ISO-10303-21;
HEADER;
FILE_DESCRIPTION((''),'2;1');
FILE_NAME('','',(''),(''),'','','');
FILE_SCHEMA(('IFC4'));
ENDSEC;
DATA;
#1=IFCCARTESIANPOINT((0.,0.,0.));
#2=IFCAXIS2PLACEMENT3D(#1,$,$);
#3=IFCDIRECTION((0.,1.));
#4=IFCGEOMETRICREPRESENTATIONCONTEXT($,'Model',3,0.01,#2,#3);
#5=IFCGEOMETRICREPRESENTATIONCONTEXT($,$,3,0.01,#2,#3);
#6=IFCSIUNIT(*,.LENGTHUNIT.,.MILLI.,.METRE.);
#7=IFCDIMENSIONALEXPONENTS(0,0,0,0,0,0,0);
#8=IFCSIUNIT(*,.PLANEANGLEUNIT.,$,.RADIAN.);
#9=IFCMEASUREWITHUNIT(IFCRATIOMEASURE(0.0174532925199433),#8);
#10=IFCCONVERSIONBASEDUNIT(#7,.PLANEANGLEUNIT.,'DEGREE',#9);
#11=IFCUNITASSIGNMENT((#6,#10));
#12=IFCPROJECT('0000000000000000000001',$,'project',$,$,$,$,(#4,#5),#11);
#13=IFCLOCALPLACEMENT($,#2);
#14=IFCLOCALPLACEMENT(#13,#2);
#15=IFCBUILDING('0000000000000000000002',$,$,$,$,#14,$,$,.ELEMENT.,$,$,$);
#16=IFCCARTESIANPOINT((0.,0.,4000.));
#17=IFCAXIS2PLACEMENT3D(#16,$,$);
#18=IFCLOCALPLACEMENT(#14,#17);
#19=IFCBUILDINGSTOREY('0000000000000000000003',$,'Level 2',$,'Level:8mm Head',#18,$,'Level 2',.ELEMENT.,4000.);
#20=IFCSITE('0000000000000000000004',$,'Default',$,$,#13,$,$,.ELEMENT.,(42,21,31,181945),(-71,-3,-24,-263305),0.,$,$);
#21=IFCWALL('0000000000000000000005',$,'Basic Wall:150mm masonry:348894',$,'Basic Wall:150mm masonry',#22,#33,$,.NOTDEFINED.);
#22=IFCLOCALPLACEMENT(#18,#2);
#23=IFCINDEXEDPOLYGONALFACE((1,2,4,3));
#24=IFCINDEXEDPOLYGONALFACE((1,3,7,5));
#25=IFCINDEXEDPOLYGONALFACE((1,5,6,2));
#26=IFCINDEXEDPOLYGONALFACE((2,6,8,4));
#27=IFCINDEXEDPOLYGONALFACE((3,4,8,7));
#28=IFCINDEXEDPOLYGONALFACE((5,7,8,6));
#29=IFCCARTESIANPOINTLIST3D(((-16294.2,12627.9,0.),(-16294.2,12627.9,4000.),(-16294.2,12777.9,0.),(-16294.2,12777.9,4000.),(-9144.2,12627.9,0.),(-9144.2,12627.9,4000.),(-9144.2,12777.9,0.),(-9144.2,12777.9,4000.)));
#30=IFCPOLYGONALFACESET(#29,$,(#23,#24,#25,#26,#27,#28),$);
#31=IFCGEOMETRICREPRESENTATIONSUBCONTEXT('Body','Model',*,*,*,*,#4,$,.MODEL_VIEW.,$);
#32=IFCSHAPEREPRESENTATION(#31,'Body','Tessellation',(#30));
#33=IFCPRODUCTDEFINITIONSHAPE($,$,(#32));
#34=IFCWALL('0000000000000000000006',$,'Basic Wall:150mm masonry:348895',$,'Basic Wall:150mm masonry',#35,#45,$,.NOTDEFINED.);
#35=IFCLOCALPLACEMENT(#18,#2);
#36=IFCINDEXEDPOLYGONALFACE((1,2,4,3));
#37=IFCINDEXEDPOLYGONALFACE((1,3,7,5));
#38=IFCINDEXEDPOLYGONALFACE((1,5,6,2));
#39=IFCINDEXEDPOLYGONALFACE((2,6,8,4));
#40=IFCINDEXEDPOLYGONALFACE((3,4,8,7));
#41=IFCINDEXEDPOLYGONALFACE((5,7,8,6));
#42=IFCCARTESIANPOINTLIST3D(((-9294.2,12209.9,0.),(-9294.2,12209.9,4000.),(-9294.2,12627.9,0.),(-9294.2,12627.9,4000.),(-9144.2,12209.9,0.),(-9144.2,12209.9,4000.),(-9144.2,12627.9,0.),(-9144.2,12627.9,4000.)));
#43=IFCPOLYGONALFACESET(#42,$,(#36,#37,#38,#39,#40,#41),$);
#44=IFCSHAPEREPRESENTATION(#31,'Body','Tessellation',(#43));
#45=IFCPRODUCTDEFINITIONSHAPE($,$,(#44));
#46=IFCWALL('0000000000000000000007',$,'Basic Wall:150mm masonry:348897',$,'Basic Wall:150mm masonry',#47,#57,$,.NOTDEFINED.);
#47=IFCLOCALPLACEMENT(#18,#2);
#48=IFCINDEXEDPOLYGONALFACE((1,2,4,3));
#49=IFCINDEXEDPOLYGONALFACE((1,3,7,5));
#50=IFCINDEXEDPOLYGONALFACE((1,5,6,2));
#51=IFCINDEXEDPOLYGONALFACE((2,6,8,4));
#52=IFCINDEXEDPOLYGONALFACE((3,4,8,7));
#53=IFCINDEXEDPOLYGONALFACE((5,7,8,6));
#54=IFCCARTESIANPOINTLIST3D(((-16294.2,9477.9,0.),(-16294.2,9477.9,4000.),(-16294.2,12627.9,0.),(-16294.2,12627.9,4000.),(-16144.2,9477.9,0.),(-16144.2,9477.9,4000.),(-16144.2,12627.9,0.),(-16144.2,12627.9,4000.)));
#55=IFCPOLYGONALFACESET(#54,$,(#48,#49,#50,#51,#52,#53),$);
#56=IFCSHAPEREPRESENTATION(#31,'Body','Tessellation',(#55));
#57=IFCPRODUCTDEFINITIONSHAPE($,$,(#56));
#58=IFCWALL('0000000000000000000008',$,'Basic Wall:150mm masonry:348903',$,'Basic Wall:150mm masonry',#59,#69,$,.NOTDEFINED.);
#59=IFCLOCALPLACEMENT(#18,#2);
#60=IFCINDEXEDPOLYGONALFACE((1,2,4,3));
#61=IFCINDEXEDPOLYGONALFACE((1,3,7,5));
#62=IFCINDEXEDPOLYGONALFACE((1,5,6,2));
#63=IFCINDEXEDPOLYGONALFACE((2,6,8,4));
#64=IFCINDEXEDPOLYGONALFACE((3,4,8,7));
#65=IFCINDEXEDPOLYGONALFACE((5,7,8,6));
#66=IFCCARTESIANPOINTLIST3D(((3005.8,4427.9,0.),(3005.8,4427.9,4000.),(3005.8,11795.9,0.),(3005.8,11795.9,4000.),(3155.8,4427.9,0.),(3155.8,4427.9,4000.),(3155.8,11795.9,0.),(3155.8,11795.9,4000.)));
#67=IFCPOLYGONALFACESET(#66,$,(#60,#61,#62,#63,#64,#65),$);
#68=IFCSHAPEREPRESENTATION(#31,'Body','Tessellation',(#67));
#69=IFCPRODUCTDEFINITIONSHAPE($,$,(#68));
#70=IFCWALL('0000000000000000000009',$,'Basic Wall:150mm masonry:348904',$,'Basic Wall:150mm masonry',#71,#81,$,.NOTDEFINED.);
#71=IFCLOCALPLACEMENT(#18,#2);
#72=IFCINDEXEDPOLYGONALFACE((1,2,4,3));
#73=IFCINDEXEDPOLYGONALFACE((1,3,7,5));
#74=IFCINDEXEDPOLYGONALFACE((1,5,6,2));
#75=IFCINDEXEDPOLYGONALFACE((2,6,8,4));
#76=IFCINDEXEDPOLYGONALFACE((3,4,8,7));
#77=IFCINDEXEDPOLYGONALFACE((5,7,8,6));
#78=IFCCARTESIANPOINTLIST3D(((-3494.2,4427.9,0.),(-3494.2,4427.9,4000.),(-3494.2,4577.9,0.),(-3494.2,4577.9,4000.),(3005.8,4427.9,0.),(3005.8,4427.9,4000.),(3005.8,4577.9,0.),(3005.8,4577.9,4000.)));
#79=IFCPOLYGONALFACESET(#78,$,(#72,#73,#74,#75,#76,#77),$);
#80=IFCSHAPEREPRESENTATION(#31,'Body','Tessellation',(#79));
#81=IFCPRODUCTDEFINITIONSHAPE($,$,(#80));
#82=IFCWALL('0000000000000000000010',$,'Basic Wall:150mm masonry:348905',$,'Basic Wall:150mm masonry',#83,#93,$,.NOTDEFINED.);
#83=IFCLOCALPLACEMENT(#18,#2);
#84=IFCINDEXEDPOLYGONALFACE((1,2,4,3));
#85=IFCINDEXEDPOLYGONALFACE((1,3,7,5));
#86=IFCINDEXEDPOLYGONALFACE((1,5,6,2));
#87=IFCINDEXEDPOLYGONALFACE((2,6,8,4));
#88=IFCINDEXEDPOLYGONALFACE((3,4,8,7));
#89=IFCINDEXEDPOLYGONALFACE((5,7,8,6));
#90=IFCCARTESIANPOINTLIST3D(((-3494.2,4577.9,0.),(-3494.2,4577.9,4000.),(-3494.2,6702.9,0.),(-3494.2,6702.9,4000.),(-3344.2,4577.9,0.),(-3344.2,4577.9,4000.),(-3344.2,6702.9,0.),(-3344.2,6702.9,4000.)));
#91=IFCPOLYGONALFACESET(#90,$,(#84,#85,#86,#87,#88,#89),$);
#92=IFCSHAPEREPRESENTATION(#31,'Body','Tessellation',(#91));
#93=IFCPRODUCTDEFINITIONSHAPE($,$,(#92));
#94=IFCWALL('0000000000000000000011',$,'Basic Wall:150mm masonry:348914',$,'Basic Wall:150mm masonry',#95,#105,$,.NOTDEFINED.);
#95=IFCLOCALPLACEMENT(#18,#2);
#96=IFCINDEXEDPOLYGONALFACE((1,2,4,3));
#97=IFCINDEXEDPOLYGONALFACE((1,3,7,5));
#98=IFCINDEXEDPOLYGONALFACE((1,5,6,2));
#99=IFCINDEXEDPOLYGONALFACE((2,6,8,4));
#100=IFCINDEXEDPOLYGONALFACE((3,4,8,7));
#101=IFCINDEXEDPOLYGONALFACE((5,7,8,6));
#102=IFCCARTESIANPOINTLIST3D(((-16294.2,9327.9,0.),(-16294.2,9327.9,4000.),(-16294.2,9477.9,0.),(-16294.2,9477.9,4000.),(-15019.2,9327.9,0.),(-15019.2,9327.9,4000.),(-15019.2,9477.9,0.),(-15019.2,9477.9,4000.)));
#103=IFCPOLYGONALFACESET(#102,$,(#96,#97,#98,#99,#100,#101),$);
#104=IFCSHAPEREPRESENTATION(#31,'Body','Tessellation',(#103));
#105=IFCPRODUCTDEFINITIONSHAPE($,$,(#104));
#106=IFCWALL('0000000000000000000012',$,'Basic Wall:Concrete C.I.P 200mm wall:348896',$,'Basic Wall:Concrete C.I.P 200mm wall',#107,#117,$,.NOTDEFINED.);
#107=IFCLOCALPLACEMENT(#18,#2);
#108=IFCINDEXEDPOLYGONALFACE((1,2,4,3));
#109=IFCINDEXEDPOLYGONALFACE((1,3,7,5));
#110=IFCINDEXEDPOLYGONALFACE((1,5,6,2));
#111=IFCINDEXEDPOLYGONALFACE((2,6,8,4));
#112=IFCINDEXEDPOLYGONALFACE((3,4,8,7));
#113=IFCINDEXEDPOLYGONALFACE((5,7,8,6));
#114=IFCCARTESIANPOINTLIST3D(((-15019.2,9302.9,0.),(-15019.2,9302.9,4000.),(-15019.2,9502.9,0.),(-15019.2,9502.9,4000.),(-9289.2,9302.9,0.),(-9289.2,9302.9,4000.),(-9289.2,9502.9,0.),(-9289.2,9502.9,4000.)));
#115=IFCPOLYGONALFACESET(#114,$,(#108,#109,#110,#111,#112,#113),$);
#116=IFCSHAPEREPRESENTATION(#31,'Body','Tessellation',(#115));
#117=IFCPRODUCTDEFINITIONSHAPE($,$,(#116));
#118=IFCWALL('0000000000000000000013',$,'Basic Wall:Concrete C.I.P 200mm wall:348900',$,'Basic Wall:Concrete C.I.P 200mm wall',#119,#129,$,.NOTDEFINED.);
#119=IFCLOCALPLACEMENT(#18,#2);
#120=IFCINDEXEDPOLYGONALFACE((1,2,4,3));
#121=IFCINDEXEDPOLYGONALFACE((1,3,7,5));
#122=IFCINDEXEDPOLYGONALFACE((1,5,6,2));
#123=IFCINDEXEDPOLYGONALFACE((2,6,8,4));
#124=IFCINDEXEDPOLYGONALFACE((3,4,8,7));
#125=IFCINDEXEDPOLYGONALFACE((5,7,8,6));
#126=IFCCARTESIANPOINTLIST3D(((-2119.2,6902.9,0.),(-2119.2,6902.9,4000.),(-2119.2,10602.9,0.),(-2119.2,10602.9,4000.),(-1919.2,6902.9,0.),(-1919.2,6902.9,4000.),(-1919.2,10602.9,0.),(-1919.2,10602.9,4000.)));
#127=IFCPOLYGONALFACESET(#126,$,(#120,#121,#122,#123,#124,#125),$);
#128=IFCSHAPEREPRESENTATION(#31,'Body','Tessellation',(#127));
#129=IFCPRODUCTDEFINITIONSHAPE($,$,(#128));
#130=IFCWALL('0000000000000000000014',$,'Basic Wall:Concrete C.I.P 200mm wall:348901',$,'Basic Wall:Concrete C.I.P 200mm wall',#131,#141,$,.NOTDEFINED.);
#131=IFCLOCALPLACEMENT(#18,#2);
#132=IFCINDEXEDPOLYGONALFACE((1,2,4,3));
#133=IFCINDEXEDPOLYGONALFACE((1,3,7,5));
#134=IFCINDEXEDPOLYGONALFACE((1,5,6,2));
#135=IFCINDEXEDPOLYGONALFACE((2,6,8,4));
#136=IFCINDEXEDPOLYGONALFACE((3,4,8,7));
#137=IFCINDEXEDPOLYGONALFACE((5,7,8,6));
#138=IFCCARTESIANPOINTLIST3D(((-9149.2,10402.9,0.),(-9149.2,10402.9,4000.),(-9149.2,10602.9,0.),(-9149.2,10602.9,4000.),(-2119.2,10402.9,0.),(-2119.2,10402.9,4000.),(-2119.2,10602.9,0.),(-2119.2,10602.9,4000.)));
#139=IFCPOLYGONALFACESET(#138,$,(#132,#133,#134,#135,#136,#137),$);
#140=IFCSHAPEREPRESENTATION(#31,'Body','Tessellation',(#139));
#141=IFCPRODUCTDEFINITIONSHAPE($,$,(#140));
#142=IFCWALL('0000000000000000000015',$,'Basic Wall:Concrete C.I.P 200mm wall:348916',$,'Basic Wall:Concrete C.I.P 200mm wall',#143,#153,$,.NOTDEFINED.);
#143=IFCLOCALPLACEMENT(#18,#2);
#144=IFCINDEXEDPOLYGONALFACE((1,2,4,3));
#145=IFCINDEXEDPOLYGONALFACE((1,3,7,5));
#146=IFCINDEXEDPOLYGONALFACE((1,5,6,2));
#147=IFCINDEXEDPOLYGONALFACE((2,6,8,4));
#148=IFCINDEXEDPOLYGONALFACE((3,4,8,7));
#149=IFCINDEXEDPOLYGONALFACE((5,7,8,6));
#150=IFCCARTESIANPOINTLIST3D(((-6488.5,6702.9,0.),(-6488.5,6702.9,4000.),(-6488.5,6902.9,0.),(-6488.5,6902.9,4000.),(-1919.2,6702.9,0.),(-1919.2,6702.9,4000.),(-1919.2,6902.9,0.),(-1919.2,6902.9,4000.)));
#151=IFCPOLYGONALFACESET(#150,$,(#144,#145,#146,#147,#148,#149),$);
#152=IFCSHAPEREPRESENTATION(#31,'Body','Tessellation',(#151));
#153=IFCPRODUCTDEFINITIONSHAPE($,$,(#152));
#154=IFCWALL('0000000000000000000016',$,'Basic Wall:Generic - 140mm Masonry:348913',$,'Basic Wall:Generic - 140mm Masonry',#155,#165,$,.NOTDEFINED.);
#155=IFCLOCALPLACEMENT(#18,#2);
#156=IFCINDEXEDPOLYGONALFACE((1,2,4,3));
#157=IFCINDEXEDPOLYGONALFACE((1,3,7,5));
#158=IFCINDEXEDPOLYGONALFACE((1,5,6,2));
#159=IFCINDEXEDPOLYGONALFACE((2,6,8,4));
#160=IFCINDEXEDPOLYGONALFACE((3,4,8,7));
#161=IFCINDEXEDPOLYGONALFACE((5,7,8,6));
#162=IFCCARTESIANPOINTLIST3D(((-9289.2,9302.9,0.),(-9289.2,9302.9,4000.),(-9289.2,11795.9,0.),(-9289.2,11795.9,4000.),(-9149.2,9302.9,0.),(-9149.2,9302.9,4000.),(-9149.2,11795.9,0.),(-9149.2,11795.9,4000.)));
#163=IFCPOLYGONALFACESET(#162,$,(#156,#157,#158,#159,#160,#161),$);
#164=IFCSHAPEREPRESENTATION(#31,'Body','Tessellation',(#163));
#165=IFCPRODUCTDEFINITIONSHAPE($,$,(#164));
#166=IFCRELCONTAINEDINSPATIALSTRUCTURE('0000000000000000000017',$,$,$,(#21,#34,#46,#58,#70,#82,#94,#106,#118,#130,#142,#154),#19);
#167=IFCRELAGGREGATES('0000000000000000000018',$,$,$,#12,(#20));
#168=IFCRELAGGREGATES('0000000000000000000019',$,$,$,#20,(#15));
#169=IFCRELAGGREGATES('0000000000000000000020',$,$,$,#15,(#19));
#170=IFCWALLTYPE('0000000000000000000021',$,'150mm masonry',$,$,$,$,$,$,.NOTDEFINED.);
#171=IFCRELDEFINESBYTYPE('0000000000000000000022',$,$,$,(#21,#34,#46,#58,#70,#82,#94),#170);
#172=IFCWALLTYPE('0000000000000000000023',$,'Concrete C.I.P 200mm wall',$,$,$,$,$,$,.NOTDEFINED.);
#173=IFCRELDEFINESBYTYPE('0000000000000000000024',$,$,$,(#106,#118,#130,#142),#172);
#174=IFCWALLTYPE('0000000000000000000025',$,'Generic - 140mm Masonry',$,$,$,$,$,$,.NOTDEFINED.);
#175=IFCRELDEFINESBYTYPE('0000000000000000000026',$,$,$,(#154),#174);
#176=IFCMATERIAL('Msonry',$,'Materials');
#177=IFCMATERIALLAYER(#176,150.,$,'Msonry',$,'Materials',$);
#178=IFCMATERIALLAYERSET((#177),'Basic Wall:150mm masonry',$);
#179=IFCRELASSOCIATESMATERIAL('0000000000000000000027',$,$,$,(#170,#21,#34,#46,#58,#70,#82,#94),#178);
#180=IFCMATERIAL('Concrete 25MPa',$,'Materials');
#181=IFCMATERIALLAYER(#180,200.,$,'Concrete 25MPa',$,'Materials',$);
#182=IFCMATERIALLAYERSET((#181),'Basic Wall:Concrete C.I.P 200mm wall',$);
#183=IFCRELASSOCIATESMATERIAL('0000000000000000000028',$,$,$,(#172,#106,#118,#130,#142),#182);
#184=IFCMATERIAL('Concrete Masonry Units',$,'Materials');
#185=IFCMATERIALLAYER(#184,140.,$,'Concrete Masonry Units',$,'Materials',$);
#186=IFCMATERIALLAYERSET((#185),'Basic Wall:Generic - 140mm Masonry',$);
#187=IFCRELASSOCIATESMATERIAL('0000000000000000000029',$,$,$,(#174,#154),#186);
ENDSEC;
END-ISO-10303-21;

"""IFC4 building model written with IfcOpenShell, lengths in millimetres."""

from ifc_helpers import new_model, entity, si_unit, converted_unit, direction, frame, frame_2d, origin, place, context, subcontext, project, spatial, rectangle, extrude, material, layer, layer_set, layer_usage, type_object, element, save


model = new_model("IFC4")

# Units and contexts
model_context = context("Model", 3, precision=0.01, world=origin(), true_north=direction((0.0, 1.0)))
context_of_model = context(None, 3, precision=0.01, world=origin(), true_north=direction((0.0, 1.0)))
body_context = subcontext(model_context, "Body", "Model", "MODEL_VIEW")
ifc_project = project(units=[si_unit("LENGTHUNIT", "METRE", prefix="MILLI"), converted_unit("PLANEANGLEUNIT", "DEGREE", entity("IfcRatioMeasure", 0.0174532925199433), si_unit("PLANEANGLEUNIT", "RADIAN"), dimensions=[0, 0, 0, 0, 0, 0, 0])], contexts=[model_context, context_of_model])

# Site, building, storey
site_placement = place(None, origin())
site = spatial("IfcSite", under=ifc_project, at=site_placement, Name="Default", CompositionType="ELEMENT", RefLatitude=(42, 21, 31, 181945), RefLongitude=(-71, -3, -24, -263305), RefElevation=0.0)
building_placement = place(site_placement, origin())
building = spatial("IfcBuilding", under=site, at=building_placement, CompositionType="ELEMENT")
storey_placement = place(building_placement, frame((0.0, 0.0, 4000.0)))
storey = spatial("IfcBuildingStorey", under=building, at=storey_placement, Name="Level 2", ObjectType="Level:8mm Head", LongName="Level 2", CompositionType="ELEMENT", Elevation=4000.0)

# Walls
ifc_material_1 = material(Name="Msonry", Category="Materials")
ifc_layer_1 = layer(ifc_material_1, 150.0, Name="Msonry", Category="Materials")
ifc_layer_set_1 = layer_set([ifc_layer_1], Name="Basic Wall:150mm masonry")
ifc_layer_usage_1 = layer_usage(ifc_layer_set_1, "AXIS2", "NEGATIVE", 75.0)
wall_type_1 = type_object("IfcWallType", Name="150mm masonry", PredefinedType="NOTDEFINED", material=ifc_layer_set_1)
wall_1_placement = place(storey_placement, frame((-16294.2, 12702.9, 0.0)))
element("IfcWall", 1, at=wall_1_placement, inside=storey, type_object=wall_type_1, material=ifc_layer_usage_1, Name="Basic Wall:150mm masonry:348894", ObjectType="Basic Wall:150mm masonry", PredefinedType="NOTDEFINED", context=body_context, shape_type="SweptSolid", body=[
    extrude(rectangle(XDim=7150.0, YDim=150.0, at=frame_2d((3575.0, 0.0), x_axis=(-1.0, 0.0))), origin(), (0.0, 0.0, 1.0), 4000.0),
])
ifc_layer_usage_2 = layer_usage(ifc_layer_set_1, "AXIS2", "NEGATIVE", 75.0)
wall_2_placement = place(storey_placement, frame((-9219.2, 12627.9, 0.0), z_axis=(0.0, 0.0, 1.0), x_axis=(0.0, -1.0, 0.0)))
element("IfcWall", 2, at=wall_2_placement, inside=storey, type_object=wall_type_1, material=ifc_layer_usage_2, Name="Basic Wall:150mm masonry:348895", ObjectType="Basic Wall:150mm masonry", PredefinedType="NOTDEFINED", context=body_context, shape_type="SweptSolid", body=[
    extrude(rectangle(XDim=418.0, YDim=150.0, at=frame_2d((209.0, 0.0), x_axis=(-1.0, 0.0))), origin(), (0.0, 0.0, 1.0), 4000.0),
])
ifc_layer_usage_3 = layer_usage(ifc_layer_set_1, "AXIS2", "NEGATIVE", 75.0)
wall_3_placement = place(storey_placement, frame((-16219.2, 9477.9, 0.0), z_axis=(0.0, 0.0, 1.0), x_axis=(0.0, 1.0, 0.0)))
element("IfcWall", 3, at=wall_3_placement, inside=storey, type_object=wall_type_1, material=ifc_layer_usage_3, Name="Basic Wall:150mm masonry:348897", ObjectType="Basic Wall:150mm masonry", PredefinedType="NOTDEFINED", context=body_context, shape_type="SweptSolid", body=[
    extrude(rectangle(XDim=3150.0, YDim=150.0, at=frame_2d((1575.0, 0.0), x_axis=(-1.0, 0.0))), origin(), (0.0, 0.0, 1.0), 4000.0),
])
ifc_layer_usage_4 = layer_usage(ifc_layer_set_1, "AXIS2", "NEGATIVE", 75.0)
wall_4_placement = place(storey_placement, frame((3080.8, 11795.9, 0.0), z_axis=(0.0, 0.0, 1.0), x_axis=(0.0, -1.0, 0.0)))
element("IfcWall", 4, at=wall_4_placement, inside=storey, type_object=wall_type_1, material=ifc_layer_usage_4, Name="Basic Wall:150mm masonry:348903", ObjectType="Basic Wall:150mm masonry", PredefinedType="NOTDEFINED", context=body_context, shape_type="SweptSolid", body=[
    extrude(rectangle(XDim=7368.0, YDim=150.0, at=frame_2d((3684.0, 0.0), x_axis=(-1.0, 0.0))), origin(), (0.0, 0.0, 1.0), 4000.0),
])
ifc_layer_usage_5 = layer_usage(ifc_layer_set_1, "AXIS2", "NEGATIVE", 75.0)
wall_5_placement = place(storey_placement, frame((3005.8, 4502.9, 0.0), z_axis=(0.0, 0.0, 1.0), x_axis=(-1.0, 0.0, 0.0)))
element("IfcWall", 5, at=wall_5_placement, inside=storey, type_object=wall_type_1, material=ifc_layer_usage_5, Name="Basic Wall:150mm masonry:348904", ObjectType="Basic Wall:150mm masonry", PredefinedType="NOTDEFINED", context=body_context, shape_type="SweptSolid", body=[
    extrude(rectangle(XDim=6500.0, YDim=150.0, at=frame_2d((3250.0, 0.0), x_axis=(-1.0, 0.0))), origin(), (0.0, 0.0, 1.0), 4000.0),
])
ifc_layer_usage_6 = layer_usage(ifc_layer_set_1, "AXIS2", "NEGATIVE", 75.0)
wall_6_placement = place(storey_placement, frame((-3419.2, 4577.9, 0.0), z_axis=(0.0, 0.0, 1.0), x_axis=(0.0, 1.0, 0.0)))
element("IfcWall", 6, at=wall_6_placement, inside=storey, type_object=wall_type_1, material=ifc_layer_usage_6, Name="Basic Wall:150mm masonry:348905", ObjectType="Basic Wall:150mm masonry", PredefinedType="NOTDEFINED", context=body_context, shape_type="SweptSolid", body=[
    extrude(rectangle(XDim=2125.0, YDim=150.0, at=frame_2d((1062.5, 0.0), x_axis=(-1.0, 0.0))), origin(), (0.0, 0.0, 1.0), 4000.0),
])
ifc_layer_usage_7 = layer_usage(ifc_layer_set_1, "AXIS2", "NEGATIVE", 75.0)
wall_7_placement = place(storey_placement, frame((-15019.2, 9402.9, 0.0), z_axis=(0.0, 0.0, 1.0), x_axis=(-1.0, 0.0, 0.0)))
element("IfcWall", 7, at=wall_7_placement, inside=storey, type_object=wall_type_1, material=ifc_layer_usage_7, Name="Basic Wall:150mm masonry:348914", ObjectType="Basic Wall:150mm masonry", PredefinedType="NOTDEFINED", context=body_context, shape_type="SweptSolid", body=[
    extrude(rectangle(XDim=1275.0, YDim=150.0, at=frame_2d((637.5, 0.0), x_axis=(-1.0, 0.0))), origin(), (0.0, 0.0, 1.0), 4000.0),
])
ifc_material_2 = material(Name="Concrete 25MPa", Category="Materials")
ifc_layer_2 = layer(ifc_material_2, 200.0, Name="Concrete 25MPa", Category="Materials")
ifc_layer_set_2 = layer_set([ifc_layer_2], Name="Basic Wall:Concrete C.I.P 200mm wall")
ifc_layer_usage_8 = layer_usage(ifc_layer_set_2, "AXIS2", "NEGATIVE", 100.0)
wall_type_2 = type_object("IfcWallType", Name="Concrete C.I.P 200mm wall", PredefinedType="NOTDEFINED", material=ifc_layer_set_2)
wall_8_placement = place(storey_placement, frame((-9289.2, 9402.9, 0.0), z_axis=(0.0, 0.0, 1.0), x_axis=(-1.0, 0.0, 0.0)))
element("IfcWall", 8, at=wall_8_placement, inside=storey, type_object=wall_type_2, material=ifc_layer_usage_8, Name="Basic Wall:Concrete C.I.P 200mm wall:348896", ObjectType="Basic Wall:Concrete C.I.P 200mm wall", PredefinedType="NOTDEFINED", context=body_context, shape_type="SweptSolid", body=[
    extrude(rectangle(XDim=5730.0, YDim=200.0, at=frame_2d((2865.0, 0.0), x_axis=(-1.0, 0.0))), origin(), (0.0, 0.0, 1.0), 4000.0),
])
ifc_layer_usage_9 = layer_usage(ifc_layer_set_2, "AXIS2", "NEGATIVE", 100.0)
wall_9_placement = place(storey_placement, frame((-2019.2, 6902.9, 0.0), z_axis=(0.0, 0.0, 1.0), x_axis=(0.0, 1.0, 0.0)))
element("IfcWall", 9, at=wall_9_placement, inside=storey, type_object=wall_type_2, material=ifc_layer_usage_9, Name="Basic Wall:Concrete C.I.P 200mm wall:348900", ObjectType="Basic Wall:Concrete C.I.P 200mm wall", PredefinedType="NOTDEFINED", context=body_context, shape_type="SweptSolid", body=[
    extrude(rectangle(XDim=3700.0, YDim=200.0, at=frame_2d((1850.0, 0.0), x_axis=(-1.0, 0.0))), origin(), (0.0, 0.0, 1.0), 4000.0),
])
ifc_layer_usage_10 = layer_usage(ifc_layer_set_2, "AXIS2", "NEGATIVE", 100.0)
wall_10_placement = place(storey_placement, frame((-2119.2, 10502.9, 0.0), z_axis=(0.0, 0.0, 1.0), x_axis=(-1.0, 0.0, 0.0)))
element("IfcWall", 10, at=wall_10_placement, inside=storey, type_object=wall_type_2, material=ifc_layer_usage_10, Name="Basic Wall:Concrete C.I.P 200mm wall:348901", ObjectType="Basic Wall:Concrete C.I.P 200mm wall", PredefinedType="NOTDEFINED", context=body_context, shape_type="SweptSolid", body=[
    extrude(rectangle(XDim=7030.0, YDim=200.0, at=frame_2d((3515.0, 0.0), x_axis=(-1.0, 0.0))), origin(), (0.0, 0.0, 1.0), 4000.0),
])
ifc_layer_usage_11 = layer_usage(ifc_layer_set_2, "AXIS2", "NEGATIVE", 100.0)
wall_11_placement = place(storey_placement, frame((-6488.5, 6802.9, 0.0)))
element("IfcWall", 11, at=wall_11_placement, inside=storey, type_object=wall_type_2, material=ifc_layer_usage_11, Name="Basic Wall:Concrete C.I.P 200mm wall:348916", ObjectType="Basic Wall:Concrete C.I.P 200mm wall", PredefinedType="NOTDEFINED", context=body_context, shape_type="SweptSolid", body=[
    extrude(rectangle(XDim=4569.3, YDim=200.0, at=frame_2d((2284.6, 0.0), x_axis=(-1.0, 0.0))), origin(), (0.0, 0.0, 1.0), 4000.0),
])
ifc_material_3 = material(Name="Concrete Masonry Units", Category="Materials")
ifc_layer_3 = layer(ifc_material_3, 140.0, Name="Concrete Masonry Units", Category="Materials")
ifc_layer_set_3 = layer_set([ifc_layer_3], Name="Basic Wall:Generic - 140mm Masonry")
ifc_layer_usage_12 = layer_usage(ifc_layer_set_3, "AXIS2", "NEGATIVE", 70.0)
wall_type_3 = type_object("IfcWallType", Name="Generic - 140mm Masonry", PredefinedType="NOTDEFINED", material=ifc_layer_set_3)
wall_12_placement = place(storey_placement, frame((-9219.2, 11795.9, 0.0), z_axis=(0.0, 0.0, 1.0), x_axis=(0.0, -1.0, 0.0)))
element("IfcWall", 12, at=wall_12_placement, inside=storey, type_object=wall_type_3, material=ifc_layer_usage_12, Name="Basic Wall:Generic - 140mm Masonry:348913", ObjectType="Basic Wall:Generic - 140mm Masonry", PredefinedType="NOTDEFINED", context=body_context, shape_type="SweptSolid", body=[
    extrude(rectangle(XDim=2493.0, YDim=140.0, at=frame_2d((1246.5, 0.0), x_axis=(-1.0, 0.0))), origin(), (0.0, 0.0, 1.0), 4000.0),
])

save(model, "model.ifc")
